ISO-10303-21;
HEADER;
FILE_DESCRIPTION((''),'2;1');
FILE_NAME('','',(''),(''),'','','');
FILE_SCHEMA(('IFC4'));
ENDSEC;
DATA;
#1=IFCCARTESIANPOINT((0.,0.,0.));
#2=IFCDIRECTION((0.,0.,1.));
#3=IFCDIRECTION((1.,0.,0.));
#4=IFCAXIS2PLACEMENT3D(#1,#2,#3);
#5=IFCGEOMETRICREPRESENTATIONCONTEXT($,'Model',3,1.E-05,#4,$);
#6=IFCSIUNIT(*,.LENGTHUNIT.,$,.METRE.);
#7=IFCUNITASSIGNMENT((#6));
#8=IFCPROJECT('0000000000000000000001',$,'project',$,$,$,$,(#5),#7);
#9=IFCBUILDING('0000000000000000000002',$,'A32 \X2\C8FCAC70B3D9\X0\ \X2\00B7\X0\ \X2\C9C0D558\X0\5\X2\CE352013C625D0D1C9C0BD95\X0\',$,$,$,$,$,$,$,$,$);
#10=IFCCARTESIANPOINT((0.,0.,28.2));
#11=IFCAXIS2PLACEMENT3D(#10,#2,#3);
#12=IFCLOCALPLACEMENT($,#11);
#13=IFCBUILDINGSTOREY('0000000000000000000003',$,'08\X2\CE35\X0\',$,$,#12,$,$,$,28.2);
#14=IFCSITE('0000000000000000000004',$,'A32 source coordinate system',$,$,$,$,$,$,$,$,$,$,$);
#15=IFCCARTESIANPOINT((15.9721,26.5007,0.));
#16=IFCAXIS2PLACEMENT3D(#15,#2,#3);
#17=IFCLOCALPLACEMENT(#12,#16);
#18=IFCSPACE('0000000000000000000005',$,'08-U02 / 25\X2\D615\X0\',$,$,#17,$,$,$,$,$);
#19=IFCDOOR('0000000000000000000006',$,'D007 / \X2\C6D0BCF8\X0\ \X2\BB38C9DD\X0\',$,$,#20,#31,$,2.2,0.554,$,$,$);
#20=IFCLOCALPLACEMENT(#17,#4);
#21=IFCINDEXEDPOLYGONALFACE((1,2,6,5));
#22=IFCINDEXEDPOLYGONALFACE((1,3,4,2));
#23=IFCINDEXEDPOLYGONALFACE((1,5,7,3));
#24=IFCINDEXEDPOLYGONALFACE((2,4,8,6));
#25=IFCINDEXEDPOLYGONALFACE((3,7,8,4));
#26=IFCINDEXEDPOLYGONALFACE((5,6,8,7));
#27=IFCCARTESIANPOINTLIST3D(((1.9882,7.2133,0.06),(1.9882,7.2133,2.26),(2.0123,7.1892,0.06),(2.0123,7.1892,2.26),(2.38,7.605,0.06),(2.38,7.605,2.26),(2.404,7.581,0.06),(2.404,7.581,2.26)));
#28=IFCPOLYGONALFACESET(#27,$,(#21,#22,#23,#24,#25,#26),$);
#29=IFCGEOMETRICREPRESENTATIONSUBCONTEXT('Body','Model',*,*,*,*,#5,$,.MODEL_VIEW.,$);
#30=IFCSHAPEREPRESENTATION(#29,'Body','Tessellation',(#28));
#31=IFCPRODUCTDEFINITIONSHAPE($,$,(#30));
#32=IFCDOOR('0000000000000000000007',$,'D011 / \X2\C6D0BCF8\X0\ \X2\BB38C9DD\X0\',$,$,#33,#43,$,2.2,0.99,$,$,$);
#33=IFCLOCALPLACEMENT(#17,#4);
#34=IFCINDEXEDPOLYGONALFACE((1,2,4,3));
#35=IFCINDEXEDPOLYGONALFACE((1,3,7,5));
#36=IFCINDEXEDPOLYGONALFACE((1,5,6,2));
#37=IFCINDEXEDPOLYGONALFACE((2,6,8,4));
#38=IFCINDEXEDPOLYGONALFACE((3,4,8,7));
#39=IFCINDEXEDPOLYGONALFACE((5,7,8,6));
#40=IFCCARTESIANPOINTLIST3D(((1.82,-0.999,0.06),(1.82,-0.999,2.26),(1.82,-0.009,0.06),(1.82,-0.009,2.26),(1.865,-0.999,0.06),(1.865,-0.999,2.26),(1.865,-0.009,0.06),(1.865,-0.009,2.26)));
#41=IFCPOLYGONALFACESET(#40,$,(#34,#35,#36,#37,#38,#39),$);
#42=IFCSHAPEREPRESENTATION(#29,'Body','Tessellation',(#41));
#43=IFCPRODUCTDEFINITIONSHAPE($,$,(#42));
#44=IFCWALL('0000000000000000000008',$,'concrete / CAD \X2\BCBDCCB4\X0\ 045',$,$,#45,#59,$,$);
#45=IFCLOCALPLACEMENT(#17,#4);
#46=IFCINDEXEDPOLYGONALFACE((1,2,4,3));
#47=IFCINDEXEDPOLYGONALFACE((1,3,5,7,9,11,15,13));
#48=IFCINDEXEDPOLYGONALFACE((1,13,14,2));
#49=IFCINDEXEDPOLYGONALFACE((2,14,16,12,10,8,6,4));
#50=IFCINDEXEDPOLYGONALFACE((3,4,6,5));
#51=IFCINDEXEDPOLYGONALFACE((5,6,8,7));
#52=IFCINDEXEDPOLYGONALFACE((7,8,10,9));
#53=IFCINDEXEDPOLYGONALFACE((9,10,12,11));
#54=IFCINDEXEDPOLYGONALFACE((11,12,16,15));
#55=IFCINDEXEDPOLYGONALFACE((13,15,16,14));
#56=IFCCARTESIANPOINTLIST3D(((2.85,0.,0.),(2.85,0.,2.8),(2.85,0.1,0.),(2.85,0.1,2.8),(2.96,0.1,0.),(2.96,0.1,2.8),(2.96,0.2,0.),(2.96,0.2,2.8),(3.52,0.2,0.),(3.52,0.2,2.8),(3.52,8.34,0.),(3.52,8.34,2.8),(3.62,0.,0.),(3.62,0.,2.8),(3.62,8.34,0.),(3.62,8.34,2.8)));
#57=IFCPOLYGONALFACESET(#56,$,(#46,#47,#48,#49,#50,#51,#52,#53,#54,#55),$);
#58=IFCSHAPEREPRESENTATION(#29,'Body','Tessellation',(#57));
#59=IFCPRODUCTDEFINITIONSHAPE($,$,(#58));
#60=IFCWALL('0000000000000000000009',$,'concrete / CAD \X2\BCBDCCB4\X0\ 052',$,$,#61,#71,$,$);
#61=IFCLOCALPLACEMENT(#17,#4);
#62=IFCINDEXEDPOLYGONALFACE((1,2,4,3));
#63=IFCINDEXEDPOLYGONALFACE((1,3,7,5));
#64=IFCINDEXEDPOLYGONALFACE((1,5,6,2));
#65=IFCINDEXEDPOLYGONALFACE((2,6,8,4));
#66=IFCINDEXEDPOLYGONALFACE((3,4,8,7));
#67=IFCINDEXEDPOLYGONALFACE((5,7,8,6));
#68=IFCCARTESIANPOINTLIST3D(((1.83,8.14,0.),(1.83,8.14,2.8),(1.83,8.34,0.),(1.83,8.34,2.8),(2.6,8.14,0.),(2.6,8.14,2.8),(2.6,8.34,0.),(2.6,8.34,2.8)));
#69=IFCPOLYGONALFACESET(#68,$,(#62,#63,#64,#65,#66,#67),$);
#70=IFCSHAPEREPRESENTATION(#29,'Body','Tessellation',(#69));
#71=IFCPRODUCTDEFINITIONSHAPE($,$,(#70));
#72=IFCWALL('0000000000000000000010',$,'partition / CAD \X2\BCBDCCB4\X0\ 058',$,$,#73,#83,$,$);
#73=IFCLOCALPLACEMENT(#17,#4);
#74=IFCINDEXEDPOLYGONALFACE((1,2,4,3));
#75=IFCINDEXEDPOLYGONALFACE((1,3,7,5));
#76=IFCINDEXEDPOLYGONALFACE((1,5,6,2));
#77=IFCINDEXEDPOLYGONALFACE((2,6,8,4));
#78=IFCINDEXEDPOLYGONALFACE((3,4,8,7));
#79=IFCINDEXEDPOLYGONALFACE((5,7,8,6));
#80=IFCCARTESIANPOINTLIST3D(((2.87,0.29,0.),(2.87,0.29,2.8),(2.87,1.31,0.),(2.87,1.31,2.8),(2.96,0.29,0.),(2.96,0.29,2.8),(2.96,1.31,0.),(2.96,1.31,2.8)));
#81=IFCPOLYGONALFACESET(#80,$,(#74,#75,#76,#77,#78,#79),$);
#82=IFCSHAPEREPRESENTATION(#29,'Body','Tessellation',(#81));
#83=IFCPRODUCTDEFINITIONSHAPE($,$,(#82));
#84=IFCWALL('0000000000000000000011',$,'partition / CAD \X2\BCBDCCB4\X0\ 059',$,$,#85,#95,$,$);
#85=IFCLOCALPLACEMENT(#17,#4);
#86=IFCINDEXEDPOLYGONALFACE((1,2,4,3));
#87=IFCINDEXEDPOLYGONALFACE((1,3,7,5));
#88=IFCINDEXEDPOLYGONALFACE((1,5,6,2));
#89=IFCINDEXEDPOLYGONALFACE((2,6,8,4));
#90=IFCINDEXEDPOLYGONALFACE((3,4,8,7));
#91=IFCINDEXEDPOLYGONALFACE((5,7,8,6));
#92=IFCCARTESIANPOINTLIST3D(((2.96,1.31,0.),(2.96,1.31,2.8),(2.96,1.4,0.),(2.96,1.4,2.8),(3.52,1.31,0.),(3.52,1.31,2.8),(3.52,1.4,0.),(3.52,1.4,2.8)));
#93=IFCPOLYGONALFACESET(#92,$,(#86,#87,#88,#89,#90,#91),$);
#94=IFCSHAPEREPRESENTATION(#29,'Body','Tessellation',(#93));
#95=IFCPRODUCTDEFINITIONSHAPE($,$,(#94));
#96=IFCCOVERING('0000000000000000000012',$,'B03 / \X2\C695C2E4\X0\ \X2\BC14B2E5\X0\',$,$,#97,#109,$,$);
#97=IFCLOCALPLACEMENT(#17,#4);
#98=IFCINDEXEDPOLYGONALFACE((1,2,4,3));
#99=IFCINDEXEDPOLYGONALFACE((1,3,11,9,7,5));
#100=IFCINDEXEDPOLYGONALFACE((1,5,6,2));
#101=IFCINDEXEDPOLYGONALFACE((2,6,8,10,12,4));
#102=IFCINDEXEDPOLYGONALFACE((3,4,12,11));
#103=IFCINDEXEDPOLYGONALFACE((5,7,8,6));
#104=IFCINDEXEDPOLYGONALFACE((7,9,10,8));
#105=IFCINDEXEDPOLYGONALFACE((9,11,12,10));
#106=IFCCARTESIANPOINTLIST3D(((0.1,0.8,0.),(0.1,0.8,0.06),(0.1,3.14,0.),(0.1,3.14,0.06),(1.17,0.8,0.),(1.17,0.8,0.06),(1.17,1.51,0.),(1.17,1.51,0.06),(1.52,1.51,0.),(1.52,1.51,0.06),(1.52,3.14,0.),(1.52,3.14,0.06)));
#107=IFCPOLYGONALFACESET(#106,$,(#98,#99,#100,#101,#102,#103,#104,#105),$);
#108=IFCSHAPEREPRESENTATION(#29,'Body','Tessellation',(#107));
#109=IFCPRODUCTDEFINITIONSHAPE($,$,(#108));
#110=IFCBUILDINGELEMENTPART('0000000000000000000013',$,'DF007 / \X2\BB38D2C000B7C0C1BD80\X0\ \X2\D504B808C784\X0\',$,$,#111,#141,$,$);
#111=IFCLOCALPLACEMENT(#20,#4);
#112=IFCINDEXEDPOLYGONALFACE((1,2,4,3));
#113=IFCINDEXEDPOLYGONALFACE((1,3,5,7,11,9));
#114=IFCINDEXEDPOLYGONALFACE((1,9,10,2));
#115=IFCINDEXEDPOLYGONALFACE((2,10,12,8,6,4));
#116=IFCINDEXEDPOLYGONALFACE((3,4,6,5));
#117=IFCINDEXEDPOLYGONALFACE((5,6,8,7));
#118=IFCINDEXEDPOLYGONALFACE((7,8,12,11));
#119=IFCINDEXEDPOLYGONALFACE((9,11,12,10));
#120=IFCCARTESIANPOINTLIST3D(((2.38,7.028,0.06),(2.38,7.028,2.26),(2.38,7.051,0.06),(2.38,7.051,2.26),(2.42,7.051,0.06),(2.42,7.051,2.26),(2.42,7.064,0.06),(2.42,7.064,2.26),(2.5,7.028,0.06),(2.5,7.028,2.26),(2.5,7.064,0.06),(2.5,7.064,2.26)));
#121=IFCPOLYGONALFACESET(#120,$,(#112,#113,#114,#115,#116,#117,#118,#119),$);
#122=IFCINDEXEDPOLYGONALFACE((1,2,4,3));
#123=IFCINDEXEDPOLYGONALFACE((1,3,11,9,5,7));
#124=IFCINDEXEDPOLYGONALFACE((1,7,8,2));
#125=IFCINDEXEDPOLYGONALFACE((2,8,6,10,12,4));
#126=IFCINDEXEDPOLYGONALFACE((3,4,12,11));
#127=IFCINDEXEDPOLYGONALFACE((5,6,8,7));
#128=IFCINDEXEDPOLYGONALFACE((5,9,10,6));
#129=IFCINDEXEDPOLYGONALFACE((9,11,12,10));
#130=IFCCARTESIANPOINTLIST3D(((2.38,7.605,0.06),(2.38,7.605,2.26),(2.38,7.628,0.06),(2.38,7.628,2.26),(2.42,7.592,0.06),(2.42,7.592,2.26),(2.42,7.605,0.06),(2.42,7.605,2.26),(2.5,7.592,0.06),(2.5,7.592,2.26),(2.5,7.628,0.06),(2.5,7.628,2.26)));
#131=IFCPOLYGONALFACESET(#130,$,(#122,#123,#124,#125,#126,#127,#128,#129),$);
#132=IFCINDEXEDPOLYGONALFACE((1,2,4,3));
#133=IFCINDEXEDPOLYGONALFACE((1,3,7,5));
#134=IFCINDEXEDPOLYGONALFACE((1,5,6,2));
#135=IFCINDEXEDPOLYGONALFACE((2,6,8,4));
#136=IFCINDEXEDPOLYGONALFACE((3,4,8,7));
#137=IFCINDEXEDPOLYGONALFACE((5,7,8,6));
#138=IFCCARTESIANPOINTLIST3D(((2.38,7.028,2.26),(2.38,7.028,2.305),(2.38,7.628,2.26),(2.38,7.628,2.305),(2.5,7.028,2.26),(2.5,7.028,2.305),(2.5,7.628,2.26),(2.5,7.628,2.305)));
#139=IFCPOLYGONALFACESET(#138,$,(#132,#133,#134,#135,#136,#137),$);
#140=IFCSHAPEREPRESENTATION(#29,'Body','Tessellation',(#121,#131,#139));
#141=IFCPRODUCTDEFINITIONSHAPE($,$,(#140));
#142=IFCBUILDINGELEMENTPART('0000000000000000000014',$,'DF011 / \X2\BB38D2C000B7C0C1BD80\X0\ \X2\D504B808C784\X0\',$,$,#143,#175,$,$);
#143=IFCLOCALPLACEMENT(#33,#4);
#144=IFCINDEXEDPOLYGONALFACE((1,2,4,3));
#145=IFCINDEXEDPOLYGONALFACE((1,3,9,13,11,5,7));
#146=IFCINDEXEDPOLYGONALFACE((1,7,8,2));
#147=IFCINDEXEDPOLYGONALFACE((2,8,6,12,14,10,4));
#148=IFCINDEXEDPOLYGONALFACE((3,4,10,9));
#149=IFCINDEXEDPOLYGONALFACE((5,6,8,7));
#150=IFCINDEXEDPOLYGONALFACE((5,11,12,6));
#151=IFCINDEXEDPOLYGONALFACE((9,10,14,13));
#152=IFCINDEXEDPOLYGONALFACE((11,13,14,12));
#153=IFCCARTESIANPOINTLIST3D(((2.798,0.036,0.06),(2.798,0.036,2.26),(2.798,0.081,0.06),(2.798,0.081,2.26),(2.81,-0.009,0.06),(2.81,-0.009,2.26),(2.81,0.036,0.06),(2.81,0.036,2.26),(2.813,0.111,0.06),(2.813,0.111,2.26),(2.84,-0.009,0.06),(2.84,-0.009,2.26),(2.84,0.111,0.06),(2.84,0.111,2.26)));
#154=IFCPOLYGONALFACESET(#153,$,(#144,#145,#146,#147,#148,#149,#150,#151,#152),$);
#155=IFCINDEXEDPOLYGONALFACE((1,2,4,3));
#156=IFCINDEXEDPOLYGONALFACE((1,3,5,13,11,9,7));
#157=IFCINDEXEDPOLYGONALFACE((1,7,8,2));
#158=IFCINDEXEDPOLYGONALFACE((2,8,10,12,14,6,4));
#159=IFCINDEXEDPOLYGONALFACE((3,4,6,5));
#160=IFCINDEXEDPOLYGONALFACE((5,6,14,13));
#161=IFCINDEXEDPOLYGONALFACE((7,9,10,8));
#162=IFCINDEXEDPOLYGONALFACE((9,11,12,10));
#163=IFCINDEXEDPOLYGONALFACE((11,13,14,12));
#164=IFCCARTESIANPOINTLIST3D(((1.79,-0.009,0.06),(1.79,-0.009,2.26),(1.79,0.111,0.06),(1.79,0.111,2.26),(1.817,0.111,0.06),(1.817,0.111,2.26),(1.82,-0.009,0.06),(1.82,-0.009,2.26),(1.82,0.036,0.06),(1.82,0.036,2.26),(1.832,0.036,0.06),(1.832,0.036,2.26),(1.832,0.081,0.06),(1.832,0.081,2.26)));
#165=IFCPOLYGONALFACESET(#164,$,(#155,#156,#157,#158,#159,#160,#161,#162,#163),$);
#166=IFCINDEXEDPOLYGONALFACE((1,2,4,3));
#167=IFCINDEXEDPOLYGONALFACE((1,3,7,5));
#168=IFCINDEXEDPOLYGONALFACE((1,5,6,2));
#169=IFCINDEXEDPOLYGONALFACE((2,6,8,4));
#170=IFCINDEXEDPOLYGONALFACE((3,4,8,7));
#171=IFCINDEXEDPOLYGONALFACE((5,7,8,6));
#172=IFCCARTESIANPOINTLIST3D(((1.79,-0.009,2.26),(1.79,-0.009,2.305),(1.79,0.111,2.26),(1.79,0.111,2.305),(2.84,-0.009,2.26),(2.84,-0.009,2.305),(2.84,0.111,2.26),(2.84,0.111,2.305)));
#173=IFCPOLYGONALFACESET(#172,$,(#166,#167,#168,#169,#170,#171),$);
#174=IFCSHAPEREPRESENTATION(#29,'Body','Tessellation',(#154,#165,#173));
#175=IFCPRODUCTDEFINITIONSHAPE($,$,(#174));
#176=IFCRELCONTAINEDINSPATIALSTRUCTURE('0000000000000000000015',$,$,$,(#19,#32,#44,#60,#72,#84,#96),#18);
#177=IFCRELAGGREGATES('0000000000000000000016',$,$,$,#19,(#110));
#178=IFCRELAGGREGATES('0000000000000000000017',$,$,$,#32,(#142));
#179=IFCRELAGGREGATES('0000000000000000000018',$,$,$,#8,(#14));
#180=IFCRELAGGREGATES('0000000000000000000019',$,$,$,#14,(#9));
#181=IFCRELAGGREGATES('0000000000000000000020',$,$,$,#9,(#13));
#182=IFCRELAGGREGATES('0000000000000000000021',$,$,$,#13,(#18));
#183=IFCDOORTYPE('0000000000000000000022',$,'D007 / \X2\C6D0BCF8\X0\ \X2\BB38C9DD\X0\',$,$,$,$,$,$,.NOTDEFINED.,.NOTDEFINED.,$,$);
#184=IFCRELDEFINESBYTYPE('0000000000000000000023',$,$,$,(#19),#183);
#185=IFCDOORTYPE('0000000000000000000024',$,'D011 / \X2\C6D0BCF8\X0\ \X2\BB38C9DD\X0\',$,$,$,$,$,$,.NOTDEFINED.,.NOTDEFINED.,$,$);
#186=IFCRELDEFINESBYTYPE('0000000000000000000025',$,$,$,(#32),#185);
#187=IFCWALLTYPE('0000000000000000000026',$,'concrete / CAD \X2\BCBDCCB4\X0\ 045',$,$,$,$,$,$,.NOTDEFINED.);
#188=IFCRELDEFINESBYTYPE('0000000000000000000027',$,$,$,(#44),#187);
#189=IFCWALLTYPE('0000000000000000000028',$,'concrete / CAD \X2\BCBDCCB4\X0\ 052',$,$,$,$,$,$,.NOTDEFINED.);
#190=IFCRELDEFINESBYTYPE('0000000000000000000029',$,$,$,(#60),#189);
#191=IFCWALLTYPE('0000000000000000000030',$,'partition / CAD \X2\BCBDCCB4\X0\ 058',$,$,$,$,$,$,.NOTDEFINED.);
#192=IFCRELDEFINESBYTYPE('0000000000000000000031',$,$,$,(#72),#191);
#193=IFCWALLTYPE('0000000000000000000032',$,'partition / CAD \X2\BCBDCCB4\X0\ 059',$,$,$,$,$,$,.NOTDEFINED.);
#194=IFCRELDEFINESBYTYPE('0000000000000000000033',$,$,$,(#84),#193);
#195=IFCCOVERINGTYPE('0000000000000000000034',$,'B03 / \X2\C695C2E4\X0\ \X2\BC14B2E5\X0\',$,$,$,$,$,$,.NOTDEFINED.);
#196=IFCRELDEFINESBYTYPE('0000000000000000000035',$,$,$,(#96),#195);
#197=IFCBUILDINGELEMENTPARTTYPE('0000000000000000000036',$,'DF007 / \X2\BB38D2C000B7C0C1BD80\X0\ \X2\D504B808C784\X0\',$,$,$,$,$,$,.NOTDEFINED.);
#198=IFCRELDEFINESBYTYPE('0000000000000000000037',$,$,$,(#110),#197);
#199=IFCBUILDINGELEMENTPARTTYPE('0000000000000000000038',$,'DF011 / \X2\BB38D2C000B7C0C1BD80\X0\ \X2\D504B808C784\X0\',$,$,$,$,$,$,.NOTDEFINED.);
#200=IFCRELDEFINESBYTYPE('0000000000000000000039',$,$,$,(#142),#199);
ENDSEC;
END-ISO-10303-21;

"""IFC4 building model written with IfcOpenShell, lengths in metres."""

from ifc_helpers import new_model, si_unit, frame, origin, origin_with_axes, place, context, subcontext, project, spatial, polyline, outline, extrude, source, transform, mapped, type_object, type_shapes, element, aggregate, save


model = new_model("IFC4")

# Units and contexts
model_context = context("Model", 3, precision=1e-05, world=origin_with_axes())
body_context = subcontext(model_context, "Body", "Model", "MODEL_VIEW")
ifc_project = project(units=[si_unit("LENGTHUNIT", "METRE")], contexts=[model_context])

# Site, building, storey, space
storey_placement = place(None, frame((0.0, 0.0, 28.2), z_axis=(0.0, 0.0, 1.0), x_axis=(1.0, 0.0, 0.0)))
space_placement = place(storey_placement, frame((15.9721, 26.5007, 0.0), z_axis=(0.0, 0.0, 1.0), x_axis=(1.0, 0.0, 0.0)))
site = spatial("IfcSite", under=ifc_project, Name="A32 source coordinate system")
building = spatial("IfcBuilding", under=site, Name="A32 주거동 · 지하5층–옥탑지붕")
storey = spatial("IfcBuildingStorey", under=building, at=storey_placement, Name="08층", Elevation=28.2)
space = spatial("IfcSpace", under=storey, at=space_placement, Name="08-U02 / 25형")

# Doors
door_type_1 = type_object("IfcDoorType", Name="D007 / 원본 문짝", OperationType="NOTDEFINED", PredefinedType="NOTDEFINED")
shared_shape_1 = source(origin(), body_context, "Body", "SweptSolid", [
    extrude(outline(polyline([(2.0123, 7.1892), (1.9882, 7.2133), (2.38, 7.605), (2.404, 7.581), (2.0123, 7.1892)])), frame((0.0, 0.0, 0.06)), (0.0, 0.0, 1.0), 2.2),
])
type_shapes(door_type_1, [shared_shape_1])
door_1_placement = place(space_placement, origin_with_axes())
door_1 = element("IfcDoor", 1, at=door_1_placement, inside=space, type_object=door_type_1, Name="D007 / 원본 문짝", OverallHeight=2.2, OverallWidth=0.554, context=body_context, shape_type="MappedRepresentation", body=[
    mapped(shared_shape_1, transform((0.0, 0.0, 0.0), scale=1.0)),
])
door_type_2 = type_object("IfcDoorType", Name="D011 / 원본 문짝", OperationType="NOTDEFINED", PredefinedType="NOTDEFINED")
shared_shape_2 = source(origin(), body_context, "Body", "SweptSolid", [
    extrude(outline(polyline([(1.865, -0.999), (1.82, -0.999), (1.82, -0.009), (1.865, -0.009), (1.865, -0.999)])), frame((0.0, 0.0, 0.06)), (0.0, 0.0, 1.0), 2.2),
])
type_shapes(door_type_2, [shared_shape_2])
door_2_placement = place(space_placement, origin_with_axes())
door_2 = element("IfcDoor", 2, at=door_2_placement, inside=space, type_object=door_type_2, Name="D011 / 원본 문짝", OverallHeight=2.2, OverallWidth=0.99, context=body_context, shape_type="MappedRepresentation", body=[
    mapped(shared_shape_2, transform((0.0, 0.0, 0.0), scale=1.0)),
])

# Walls
wall_type_1 = type_object("IfcWallType", Name="concrete / CAD 벽체 045", PredefinedType="NOTDEFINED")
shared_shape_3 = source(origin(), body_context, "Body", "SweptSolid", [
    extrude(outline(polyline([(2.96, 0.1), (2.96, 0.2), (3.52, 0.2), (3.52, 8.34), (3.72, 8.34), (3.72, 8.34), (3.62, 8.34), (3.62, 0.0), (2.85, 0.0), (2.85, 0.1), (2.96, 0.1)])), origin(), (0.0, 0.0, 1.0), 2.8),
])
type_shapes(wall_type_1, [shared_shape_3])
wall_1_placement = place(space_placement, origin_with_axes())
element("IfcWall", 3, at=wall_1_placement, inside=space, type_object=wall_type_1, Name="concrete / CAD 벽체 045", context=body_context, shape_type="MappedRepresentation", body=[
    mapped(shared_shape_3, transform((0.0, 0.0, 0.0), scale=1.0)),
])
wall_type_2 = type_object("IfcWallType", Name="concrete / CAD 벽체 052", PredefinedType="NOTDEFINED")
shared_shape_4 = source(origin(), body_context, "Body", "SweptSolid", [
    extrude(outline(polyline([(2.6, 8.14), (1.83, 8.14), (1.83, 8.34), (2.6, 8.34), (2.6, 8.14)])), origin(), (0.0, 0.0, 1.0), 2.8),
])
type_shapes(wall_type_2, [shared_shape_4])
wall_2_placement = place(space_placement, origin_with_axes())
element("IfcWall", 4, at=wall_2_placement, inside=space, type_object=wall_type_2, Name="concrete / CAD 벽체 052", context=body_context, shape_type="MappedRepresentation", body=[
    mapped(shared_shape_4, transform((0.0, 0.0, 0.0), scale=1.0)),
])
wall_type_3 = type_object("IfcWallType", Name="partition / CAD 벽체 058", PredefinedType="NOTDEFINED")
shared_shape_5 = source(origin(), body_context, "Body", "SweptSolid", [
    extrude(outline(polyline([(2.96, 1.31), (2.96, 0.29), (2.87, 0.29), (2.87, 1.31), (2.96, 1.31)])), origin(), (0.0, 0.0, 1.0), 2.8),
])
type_shapes(wall_type_3, [shared_shape_5])
wall_3_placement = place(space_placement, origin_with_axes())
element("IfcWall", 5, at=wall_3_placement, inside=space, type_object=wall_type_3, Name="partition / CAD 벽체 058", context=body_context, shape_type="MappedRepresentation", body=[
    mapped(shared_shape_5, transform((0.0, 0.0, 0.0), scale=1.0)),
])
wall_type_4 = type_object("IfcWallType", Name="partition / CAD 벽체 059", PredefinedType="NOTDEFINED")
shared_shape_6 = source(origin(), body_context, "Body", "SweptSolid", [
    extrude(outline(polyline([(3.52, 1.31), (2.96, 1.31), (2.96, 1.4), (3.52, 1.4), (3.52, 1.31)])), origin(), (0.0, 0.0, 1.0), 2.8),
])
type_shapes(wall_type_4, [shared_shape_6])
wall_4_placement = place(space_placement, origin_with_axes())
element("IfcWall", 6, at=wall_4_placement, inside=space, type_object=wall_type_4, Name="partition / CAD 벽체 059", context=body_context, shape_type="MappedRepresentation", body=[
    mapped(shared_shape_6, transform((0.0, 0.0, 0.0), scale=1.0)),
])

# Covering
covering_type_1 = type_object("IfcCoveringType", Name="B03 / 욕실 바닥", PredefinedType="NOTDEFINED")
shared_shape_7 = source(origin(), body_context, "Body", "SweptSolid", [
    extrude(outline(polyline([(1.17, 1.51), (1.17, 0.8), (0.1, 0.8), (0.1, 3.14), (1.52, 3.14), (1.52, 1.51), (1.17, 1.51)])), origin(), (0.0, 0.0, 1.0), 0.06),
])
type_shapes(covering_type_1, [shared_shape_7])
covering_1_placement = place(space_placement, origin_with_axes())
element("IfcCovering", 7, at=covering_1_placement, inside=space, type_object=covering_type_1, Name="B03 / 욕실 바닥", context=body_context, shape_type="MappedRepresentation", body=[
    mapped(shared_shape_7, transform((0.0, 0.0, 0.0), scale=1.0)),
])

# Building element parts
building_element_part_type_1 = type_object("IfcBuildingElementPartType", Name="DF007 / 문틀·상부 프레임", PredefinedType="NOTDEFINED")
shared_shape_8 = source(origin(), body_context, "Body", "SweptSolid", [
    extrude(outline(polyline([(2.38, 7.028), (2.38, 7.051), (2.42, 7.051), (2.42, 7.064), (2.5, 7.064), (2.5, 7.028), (2.38, 7.028)])), frame((0.0, 0.0, 0.06)), (0.0, 0.0, 1.0), 2.2),
    extrude(outline(polyline([(2.5, 7.592), (2.42, 7.592), (2.42, 7.605), (2.38, 7.605), (2.38, 7.628), (2.5, 7.628), (2.5, 7.592)])), frame((0.0, 0.0, 0.06)), (0.0, 0.0, 1.0), 2.2),
    extrude(outline(polyline([(2.38, 7.028), (2.38, 7.628), (2.5, 7.628), (2.5, 7.028), (2.38, 7.028)])), frame((0.0, 0.0, 2.26)), (0.0, 0.0, 1.0), 0.045),
])
type_shapes(building_element_part_type_1, [shared_shape_8])
building_element_part_1_placement = place(door_1_placement, origin_with_axes())
building_element_part_1 = element("IfcBuildingElementPart", 8, at=building_element_part_1_placement, type_object=building_element_part_type_1, Name="DF007 / 문틀·상부 프레임", context=body_context, shape_type="MappedRepresentation", body=[
    mapped(shared_shape_8, transform((0.0, 0.0, 0.0), scale=1.0)),
])
aggregate(door_1, [building_element_part_1])
building_element_part_type_2 = type_object("IfcBuildingElementPartType", Name="DF011 / 문틀·상부 프레임", PredefinedType="NOTDEFINED")
shared_shape_9 = source(origin(), body_context, "Body", "SweptSolid", [
    extrude(outline(polyline([(2.81, -0.009), (2.81, 0.036), (2.798, 0.036), (2.798, 0.081), (2.813, 0.111), (2.84, 0.111), (2.84, -0.009), (2.81, -0.009)])), frame((0.0, 0.0, 0.06)), (0.0, 0.0, 1.0), 2.2),
    extrude(outline(polyline([(1.79, 0.111), (1.817, 0.111), (1.832, 0.081), (1.832, 0.036), (1.82, 0.036), (1.82, -0.009), (1.79, -0.009), (1.79, 0.111)])), frame((0.0, 0.0, 0.06)), (0.0, 0.0, 1.0), 2.2),
    extrude(outline(polyline([(1.79, -0.009), (1.79, 0.111), (2.84, 0.111), (2.84, -0.009), (1.79, -0.009)])), frame((0.0, 0.0, 2.26)), (0.0, 0.0, 1.0), 0.045),
])
type_shapes(building_element_part_type_2, [shared_shape_9])
building_element_part_2_placement = place(door_2_placement, origin_with_axes())
building_element_part_2 = element("IfcBuildingElementPart", 9, at=building_element_part_2_placement, type_object=building_element_part_type_2, Name="DF011 / 문틀·상부 프레임", context=body_context, shape_type="MappedRepresentation", body=[
    mapped(shared_shape_9, transform((0.0, 0.0, 0.0), scale=1.0)),
])
aggregate(door_2, [building_element_part_2])

save(model, "model.ifc")
